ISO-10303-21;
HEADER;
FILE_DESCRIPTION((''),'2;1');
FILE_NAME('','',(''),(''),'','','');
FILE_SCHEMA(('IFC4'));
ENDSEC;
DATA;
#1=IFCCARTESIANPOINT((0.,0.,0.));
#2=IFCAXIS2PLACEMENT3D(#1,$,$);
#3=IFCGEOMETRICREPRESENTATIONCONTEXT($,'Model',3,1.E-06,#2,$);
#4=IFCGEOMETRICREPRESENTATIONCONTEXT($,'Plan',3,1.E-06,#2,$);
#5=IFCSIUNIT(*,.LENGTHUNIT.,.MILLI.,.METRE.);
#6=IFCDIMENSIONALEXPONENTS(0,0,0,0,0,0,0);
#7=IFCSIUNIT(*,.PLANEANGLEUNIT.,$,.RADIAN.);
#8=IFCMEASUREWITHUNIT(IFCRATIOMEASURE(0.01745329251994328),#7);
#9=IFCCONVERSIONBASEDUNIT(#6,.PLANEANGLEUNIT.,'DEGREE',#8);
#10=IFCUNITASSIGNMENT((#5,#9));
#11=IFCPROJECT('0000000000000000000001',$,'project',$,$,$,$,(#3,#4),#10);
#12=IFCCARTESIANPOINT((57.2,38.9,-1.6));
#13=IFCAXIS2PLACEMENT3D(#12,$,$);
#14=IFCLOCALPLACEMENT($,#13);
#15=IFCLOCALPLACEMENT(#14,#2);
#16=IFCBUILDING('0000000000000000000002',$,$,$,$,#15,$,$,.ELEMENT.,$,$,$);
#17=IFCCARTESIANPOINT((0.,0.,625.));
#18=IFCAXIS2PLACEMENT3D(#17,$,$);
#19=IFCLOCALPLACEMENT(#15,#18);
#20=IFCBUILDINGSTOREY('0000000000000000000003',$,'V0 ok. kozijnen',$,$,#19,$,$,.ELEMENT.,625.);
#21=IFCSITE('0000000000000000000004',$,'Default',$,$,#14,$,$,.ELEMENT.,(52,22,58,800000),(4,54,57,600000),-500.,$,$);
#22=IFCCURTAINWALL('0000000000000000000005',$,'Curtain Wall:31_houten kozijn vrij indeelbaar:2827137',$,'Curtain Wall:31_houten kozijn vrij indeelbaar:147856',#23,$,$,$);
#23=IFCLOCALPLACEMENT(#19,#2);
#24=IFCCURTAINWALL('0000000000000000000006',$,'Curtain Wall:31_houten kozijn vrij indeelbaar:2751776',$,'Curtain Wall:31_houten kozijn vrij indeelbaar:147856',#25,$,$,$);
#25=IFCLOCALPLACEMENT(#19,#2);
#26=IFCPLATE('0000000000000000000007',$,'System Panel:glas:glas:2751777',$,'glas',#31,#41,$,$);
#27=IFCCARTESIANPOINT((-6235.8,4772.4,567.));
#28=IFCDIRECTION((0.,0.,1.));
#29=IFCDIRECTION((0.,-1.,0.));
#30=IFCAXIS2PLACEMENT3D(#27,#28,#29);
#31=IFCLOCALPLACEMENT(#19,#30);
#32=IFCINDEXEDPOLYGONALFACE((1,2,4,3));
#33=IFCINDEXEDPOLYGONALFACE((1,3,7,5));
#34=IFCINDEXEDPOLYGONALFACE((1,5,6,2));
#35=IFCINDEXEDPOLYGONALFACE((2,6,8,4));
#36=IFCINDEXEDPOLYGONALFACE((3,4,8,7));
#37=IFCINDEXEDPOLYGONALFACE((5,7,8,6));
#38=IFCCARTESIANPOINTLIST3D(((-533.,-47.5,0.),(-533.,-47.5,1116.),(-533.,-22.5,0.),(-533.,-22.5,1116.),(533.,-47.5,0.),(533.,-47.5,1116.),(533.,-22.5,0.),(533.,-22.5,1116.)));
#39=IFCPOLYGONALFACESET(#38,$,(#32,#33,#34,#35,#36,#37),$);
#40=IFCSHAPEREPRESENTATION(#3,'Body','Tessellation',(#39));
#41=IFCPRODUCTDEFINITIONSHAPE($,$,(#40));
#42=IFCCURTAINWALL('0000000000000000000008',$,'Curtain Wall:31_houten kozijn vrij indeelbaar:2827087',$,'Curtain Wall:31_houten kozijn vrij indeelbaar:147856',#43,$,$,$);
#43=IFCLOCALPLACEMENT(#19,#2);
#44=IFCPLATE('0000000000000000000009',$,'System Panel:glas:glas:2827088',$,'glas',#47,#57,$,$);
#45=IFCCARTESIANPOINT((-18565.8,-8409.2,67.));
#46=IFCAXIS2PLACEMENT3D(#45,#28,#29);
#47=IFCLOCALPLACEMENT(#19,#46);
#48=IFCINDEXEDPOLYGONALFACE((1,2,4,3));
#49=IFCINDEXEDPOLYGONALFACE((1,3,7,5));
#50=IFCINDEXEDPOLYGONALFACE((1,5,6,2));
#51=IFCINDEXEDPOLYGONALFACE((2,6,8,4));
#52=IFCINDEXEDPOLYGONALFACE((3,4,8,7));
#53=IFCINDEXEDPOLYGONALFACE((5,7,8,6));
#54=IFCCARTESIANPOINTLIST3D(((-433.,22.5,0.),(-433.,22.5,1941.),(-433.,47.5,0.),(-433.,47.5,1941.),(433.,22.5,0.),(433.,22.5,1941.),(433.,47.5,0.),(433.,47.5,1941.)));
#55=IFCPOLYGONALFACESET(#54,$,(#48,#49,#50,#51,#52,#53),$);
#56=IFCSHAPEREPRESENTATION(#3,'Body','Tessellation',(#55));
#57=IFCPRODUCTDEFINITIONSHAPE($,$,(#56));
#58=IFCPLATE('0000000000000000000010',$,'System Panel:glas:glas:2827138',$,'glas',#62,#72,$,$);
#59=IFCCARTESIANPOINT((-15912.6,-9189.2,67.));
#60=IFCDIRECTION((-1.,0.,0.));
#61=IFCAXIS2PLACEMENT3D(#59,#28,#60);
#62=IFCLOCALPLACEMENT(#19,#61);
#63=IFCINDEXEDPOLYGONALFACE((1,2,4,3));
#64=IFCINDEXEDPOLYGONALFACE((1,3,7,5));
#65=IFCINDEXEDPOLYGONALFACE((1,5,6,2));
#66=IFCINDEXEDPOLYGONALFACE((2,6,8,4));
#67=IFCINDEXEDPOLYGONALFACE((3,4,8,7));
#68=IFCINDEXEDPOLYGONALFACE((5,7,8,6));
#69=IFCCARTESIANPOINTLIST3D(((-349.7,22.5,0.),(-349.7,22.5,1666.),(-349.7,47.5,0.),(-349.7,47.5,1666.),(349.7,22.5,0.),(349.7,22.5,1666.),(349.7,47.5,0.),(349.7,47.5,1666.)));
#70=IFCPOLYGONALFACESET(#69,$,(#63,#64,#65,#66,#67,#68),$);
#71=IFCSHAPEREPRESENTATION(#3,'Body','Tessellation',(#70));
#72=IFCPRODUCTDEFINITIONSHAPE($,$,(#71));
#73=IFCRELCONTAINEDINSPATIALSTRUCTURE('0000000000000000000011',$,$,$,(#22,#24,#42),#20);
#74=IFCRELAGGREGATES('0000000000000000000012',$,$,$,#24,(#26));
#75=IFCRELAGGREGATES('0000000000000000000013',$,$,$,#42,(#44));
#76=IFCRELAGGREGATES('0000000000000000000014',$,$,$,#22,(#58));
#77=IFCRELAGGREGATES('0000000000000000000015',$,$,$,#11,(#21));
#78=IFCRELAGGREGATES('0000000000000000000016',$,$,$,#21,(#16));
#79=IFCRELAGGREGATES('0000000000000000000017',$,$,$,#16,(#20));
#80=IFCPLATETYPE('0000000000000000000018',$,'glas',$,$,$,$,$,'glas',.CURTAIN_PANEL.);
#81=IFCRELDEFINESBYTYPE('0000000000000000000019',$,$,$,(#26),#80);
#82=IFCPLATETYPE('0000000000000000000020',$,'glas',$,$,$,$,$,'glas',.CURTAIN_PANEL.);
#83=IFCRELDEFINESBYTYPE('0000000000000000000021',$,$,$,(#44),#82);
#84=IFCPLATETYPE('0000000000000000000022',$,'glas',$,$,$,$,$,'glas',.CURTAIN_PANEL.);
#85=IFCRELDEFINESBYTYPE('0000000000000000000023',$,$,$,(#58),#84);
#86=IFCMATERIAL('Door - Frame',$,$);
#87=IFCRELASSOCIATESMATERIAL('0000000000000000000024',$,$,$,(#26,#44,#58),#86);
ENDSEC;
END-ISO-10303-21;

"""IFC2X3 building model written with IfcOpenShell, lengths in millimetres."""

from ifc_helpers import new_model, entity, si_unit, converted_unit, frame, origin, origin_2d_with_axis, place, context, project, spatial, rectangle, extrude, source, transform, mapped, material, type_object, type_shapes, element, aggregate, save


model = new_model("IFC2X3")

# Units and contexts
model_context = context("Model", 3, precision=1e-06, world=origin())
plan_context = context("Plan", 3, precision=1e-06, world=origin())
ifc_project = project(units=[si_unit("LENGTHUNIT", "METRE", prefix="MILLI"), converted_unit("PLANEANGLEUNIT", "DEGREE", entity("IfcRatioMeasure", 0.01745329251994328), si_unit("PLANEANGLEUNIT", "RADIAN"), dimensions=[0, 0, 0, 0, 0, 0, 0])], contexts=[model_context, plan_context])

# Site, building, storey
site_placement = place(None, frame((57.2, 38.9, -1.6)))
site = spatial("IfcSite", under=ifc_project, at=site_placement, Name="Default", CompositionType="ELEMENT", RefLatitude=(52, 22, 58, 800000), RefLongitude=(4, 54, 57, 600000), RefElevation=-500.0)
building_placement = place(site_placement, origin())
building = spatial("IfcBuilding", under=site, at=building_placement, CompositionType="ELEMENT")
storey_placement = place(building_placement, frame((0.0, 0.0, 625.0)))
storey = spatial("IfcBuildingStorey", under=building, at=storey_placement, Name="V0 ok. kozijnen", CompositionType="ELEMENT", Elevation=625.0)

# Curtain wall
curtain_wall_1_placement = place(storey_placement, origin())
curtain_wall_1 = element("IfcCurtainWall", 1, at=curtain_wall_1_placement, inside=storey, Name="Curtain Wall:31_houten kozijn vrij indeelbaar:2827137", ObjectType="Curtain Wall:31_houten kozijn vrij indeelbaar:147856")

# Curtain walls, plates
curtain_wall_2_placement = place(storey_placement, origin())
curtain_wall_2 = element("IfcCurtainWall", 2, at=curtain_wall_2_placement, inside=storey, Name="Curtain Wall:31_houten kozijn vrij indeelbaar:2751776", ObjectType="Curtain Wall:31_houten kozijn vrij indeelbaar:147856")
ifc_material_1 = material(Name="Door - Frame")
plate_type_1 = type_object("IfcPlateType", Name="glas", ElementType="glas", PredefinedType="CURTAIN_PANEL")
shared_shape_1 = source(origin(), model_context, "Body", "SweptSolid", [
    extrude(rectangle(XDim=25.0, YDim=1066.0, at=origin_2d_with_axis()), frame((0.0, -35.0, 0.0), z_axis=(0.0, 0.0, 1.0), x_axis=(0.0, 1.0, 0.0)), (0.0, 0.0, 1.0), 1116.0),
])
type_shapes(plate_type_1, [shared_shape_1])
plate_1_placement = place(storey_placement, frame((-6235.8, 4772.4, 567.0), z_axis=(0.0, 0.0, 1.0), x_axis=(0.0, -1.0, 0.0)))
plate_1 = element("IfcPlate", 3, at=plate_1_placement, type_object=plate_type_1, material=ifc_material_1, Name="System Panel:glas:glas:2751777", ObjectType="glas", context=model_context, shape_type="MappedRepresentation", body=[
    mapped(shared_shape_1, transform((0.0, 0.0, 0.0), scale=1.0)),
])
aggregate(curtain_wall_2, [plate_1])
curtain_wall_3_placement = place(storey_placement, origin())
curtain_wall_3 = element("IfcCurtainWall", 4, at=curtain_wall_3_placement, inside=storey, Name="Curtain Wall:31_houten kozijn vrij indeelbaar:2827087", ObjectType="Curtain Wall:31_houten kozijn vrij indeelbaar:147856")
plate_type_2 = type_object("IfcPlateType", Name="glas", ElementType="glas", PredefinedType="CURTAIN_PANEL")
shared_shape_2 = source(origin(), model_context, "Body", "SweptSolid", [
    extrude(rectangle(XDim=25.0, YDim=866.0, at=origin_2d_with_axis()), frame((0.0, 35.0, 0.0), z_axis=(0.0, 0.0, 1.0), x_axis=(0.0, 1.0, 0.0)), (0.0, 0.0, 1.0), 1941.0),
])
type_shapes(plate_type_2, [shared_shape_2])
plate_2_placement = place(storey_placement, frame((-18565.8, -8409.2, 67.0), z_axis=(0.0, 0.0, 1.0), x_axis=(0.0, -1.0, 0.0)))
plate_2 = element("IfcPlate", 5, at=plate_2_placement, type_object=plate_type_2, material=ifc_material_1, Name="System Panel:glas:glas:2827088", ObjectType="glas", context=model_context, shape_type="MappedRepresentation", body=[
    mapped(shared_shape_2, transform((0.0, 0.0, 0.0), scale=1.0)),
])
aggregate(curtain_wall_3, [plate_2])

# Plate
plate_type_3 = type_object("IfcPlateType", Name="glas", ElementType="glas", PredefinedType="CURTAIN_PANEL")
shared_shape_3 = source(origin(), model_context, "Body", "SweptSolid", [
    extrude(rectangle(XDim=25.0, YDim=699.5, at=origin_2d_with_axis()), frame((0.0, 35.0, 0.0), z_axis=(0.0, 0.0, 1.0), x_axis=(0.0, 1.0, 0.0)), (0.0, 0.0, 1.0), 1666.0),
])
type_shapes(plate_type_3, [shared_shape_3])
plate_3_placement = place(storey_placement, frame((-15912.6, -9189.2, 67.0), z_axis=(0.0, 0.0, 1.0), x_axis=(-1.0, 0.0, 0.0)))
plate_3 = element("IfcPlate", 6, at=plate_3_placement, type_object=plate_type_3, material=ifc_material_1, Name="System Panel:glas:glas:2827138", ObjectType="glas", context=model_context, shape_type="MappedRepresentation", body=[
    mapped(shared_shape_3, transform((0.0, 0.0, 0.0), scale=1.0)),
])
aggregate(curtain_wall_1, [plate_3])

save(model, "model.ifc")
